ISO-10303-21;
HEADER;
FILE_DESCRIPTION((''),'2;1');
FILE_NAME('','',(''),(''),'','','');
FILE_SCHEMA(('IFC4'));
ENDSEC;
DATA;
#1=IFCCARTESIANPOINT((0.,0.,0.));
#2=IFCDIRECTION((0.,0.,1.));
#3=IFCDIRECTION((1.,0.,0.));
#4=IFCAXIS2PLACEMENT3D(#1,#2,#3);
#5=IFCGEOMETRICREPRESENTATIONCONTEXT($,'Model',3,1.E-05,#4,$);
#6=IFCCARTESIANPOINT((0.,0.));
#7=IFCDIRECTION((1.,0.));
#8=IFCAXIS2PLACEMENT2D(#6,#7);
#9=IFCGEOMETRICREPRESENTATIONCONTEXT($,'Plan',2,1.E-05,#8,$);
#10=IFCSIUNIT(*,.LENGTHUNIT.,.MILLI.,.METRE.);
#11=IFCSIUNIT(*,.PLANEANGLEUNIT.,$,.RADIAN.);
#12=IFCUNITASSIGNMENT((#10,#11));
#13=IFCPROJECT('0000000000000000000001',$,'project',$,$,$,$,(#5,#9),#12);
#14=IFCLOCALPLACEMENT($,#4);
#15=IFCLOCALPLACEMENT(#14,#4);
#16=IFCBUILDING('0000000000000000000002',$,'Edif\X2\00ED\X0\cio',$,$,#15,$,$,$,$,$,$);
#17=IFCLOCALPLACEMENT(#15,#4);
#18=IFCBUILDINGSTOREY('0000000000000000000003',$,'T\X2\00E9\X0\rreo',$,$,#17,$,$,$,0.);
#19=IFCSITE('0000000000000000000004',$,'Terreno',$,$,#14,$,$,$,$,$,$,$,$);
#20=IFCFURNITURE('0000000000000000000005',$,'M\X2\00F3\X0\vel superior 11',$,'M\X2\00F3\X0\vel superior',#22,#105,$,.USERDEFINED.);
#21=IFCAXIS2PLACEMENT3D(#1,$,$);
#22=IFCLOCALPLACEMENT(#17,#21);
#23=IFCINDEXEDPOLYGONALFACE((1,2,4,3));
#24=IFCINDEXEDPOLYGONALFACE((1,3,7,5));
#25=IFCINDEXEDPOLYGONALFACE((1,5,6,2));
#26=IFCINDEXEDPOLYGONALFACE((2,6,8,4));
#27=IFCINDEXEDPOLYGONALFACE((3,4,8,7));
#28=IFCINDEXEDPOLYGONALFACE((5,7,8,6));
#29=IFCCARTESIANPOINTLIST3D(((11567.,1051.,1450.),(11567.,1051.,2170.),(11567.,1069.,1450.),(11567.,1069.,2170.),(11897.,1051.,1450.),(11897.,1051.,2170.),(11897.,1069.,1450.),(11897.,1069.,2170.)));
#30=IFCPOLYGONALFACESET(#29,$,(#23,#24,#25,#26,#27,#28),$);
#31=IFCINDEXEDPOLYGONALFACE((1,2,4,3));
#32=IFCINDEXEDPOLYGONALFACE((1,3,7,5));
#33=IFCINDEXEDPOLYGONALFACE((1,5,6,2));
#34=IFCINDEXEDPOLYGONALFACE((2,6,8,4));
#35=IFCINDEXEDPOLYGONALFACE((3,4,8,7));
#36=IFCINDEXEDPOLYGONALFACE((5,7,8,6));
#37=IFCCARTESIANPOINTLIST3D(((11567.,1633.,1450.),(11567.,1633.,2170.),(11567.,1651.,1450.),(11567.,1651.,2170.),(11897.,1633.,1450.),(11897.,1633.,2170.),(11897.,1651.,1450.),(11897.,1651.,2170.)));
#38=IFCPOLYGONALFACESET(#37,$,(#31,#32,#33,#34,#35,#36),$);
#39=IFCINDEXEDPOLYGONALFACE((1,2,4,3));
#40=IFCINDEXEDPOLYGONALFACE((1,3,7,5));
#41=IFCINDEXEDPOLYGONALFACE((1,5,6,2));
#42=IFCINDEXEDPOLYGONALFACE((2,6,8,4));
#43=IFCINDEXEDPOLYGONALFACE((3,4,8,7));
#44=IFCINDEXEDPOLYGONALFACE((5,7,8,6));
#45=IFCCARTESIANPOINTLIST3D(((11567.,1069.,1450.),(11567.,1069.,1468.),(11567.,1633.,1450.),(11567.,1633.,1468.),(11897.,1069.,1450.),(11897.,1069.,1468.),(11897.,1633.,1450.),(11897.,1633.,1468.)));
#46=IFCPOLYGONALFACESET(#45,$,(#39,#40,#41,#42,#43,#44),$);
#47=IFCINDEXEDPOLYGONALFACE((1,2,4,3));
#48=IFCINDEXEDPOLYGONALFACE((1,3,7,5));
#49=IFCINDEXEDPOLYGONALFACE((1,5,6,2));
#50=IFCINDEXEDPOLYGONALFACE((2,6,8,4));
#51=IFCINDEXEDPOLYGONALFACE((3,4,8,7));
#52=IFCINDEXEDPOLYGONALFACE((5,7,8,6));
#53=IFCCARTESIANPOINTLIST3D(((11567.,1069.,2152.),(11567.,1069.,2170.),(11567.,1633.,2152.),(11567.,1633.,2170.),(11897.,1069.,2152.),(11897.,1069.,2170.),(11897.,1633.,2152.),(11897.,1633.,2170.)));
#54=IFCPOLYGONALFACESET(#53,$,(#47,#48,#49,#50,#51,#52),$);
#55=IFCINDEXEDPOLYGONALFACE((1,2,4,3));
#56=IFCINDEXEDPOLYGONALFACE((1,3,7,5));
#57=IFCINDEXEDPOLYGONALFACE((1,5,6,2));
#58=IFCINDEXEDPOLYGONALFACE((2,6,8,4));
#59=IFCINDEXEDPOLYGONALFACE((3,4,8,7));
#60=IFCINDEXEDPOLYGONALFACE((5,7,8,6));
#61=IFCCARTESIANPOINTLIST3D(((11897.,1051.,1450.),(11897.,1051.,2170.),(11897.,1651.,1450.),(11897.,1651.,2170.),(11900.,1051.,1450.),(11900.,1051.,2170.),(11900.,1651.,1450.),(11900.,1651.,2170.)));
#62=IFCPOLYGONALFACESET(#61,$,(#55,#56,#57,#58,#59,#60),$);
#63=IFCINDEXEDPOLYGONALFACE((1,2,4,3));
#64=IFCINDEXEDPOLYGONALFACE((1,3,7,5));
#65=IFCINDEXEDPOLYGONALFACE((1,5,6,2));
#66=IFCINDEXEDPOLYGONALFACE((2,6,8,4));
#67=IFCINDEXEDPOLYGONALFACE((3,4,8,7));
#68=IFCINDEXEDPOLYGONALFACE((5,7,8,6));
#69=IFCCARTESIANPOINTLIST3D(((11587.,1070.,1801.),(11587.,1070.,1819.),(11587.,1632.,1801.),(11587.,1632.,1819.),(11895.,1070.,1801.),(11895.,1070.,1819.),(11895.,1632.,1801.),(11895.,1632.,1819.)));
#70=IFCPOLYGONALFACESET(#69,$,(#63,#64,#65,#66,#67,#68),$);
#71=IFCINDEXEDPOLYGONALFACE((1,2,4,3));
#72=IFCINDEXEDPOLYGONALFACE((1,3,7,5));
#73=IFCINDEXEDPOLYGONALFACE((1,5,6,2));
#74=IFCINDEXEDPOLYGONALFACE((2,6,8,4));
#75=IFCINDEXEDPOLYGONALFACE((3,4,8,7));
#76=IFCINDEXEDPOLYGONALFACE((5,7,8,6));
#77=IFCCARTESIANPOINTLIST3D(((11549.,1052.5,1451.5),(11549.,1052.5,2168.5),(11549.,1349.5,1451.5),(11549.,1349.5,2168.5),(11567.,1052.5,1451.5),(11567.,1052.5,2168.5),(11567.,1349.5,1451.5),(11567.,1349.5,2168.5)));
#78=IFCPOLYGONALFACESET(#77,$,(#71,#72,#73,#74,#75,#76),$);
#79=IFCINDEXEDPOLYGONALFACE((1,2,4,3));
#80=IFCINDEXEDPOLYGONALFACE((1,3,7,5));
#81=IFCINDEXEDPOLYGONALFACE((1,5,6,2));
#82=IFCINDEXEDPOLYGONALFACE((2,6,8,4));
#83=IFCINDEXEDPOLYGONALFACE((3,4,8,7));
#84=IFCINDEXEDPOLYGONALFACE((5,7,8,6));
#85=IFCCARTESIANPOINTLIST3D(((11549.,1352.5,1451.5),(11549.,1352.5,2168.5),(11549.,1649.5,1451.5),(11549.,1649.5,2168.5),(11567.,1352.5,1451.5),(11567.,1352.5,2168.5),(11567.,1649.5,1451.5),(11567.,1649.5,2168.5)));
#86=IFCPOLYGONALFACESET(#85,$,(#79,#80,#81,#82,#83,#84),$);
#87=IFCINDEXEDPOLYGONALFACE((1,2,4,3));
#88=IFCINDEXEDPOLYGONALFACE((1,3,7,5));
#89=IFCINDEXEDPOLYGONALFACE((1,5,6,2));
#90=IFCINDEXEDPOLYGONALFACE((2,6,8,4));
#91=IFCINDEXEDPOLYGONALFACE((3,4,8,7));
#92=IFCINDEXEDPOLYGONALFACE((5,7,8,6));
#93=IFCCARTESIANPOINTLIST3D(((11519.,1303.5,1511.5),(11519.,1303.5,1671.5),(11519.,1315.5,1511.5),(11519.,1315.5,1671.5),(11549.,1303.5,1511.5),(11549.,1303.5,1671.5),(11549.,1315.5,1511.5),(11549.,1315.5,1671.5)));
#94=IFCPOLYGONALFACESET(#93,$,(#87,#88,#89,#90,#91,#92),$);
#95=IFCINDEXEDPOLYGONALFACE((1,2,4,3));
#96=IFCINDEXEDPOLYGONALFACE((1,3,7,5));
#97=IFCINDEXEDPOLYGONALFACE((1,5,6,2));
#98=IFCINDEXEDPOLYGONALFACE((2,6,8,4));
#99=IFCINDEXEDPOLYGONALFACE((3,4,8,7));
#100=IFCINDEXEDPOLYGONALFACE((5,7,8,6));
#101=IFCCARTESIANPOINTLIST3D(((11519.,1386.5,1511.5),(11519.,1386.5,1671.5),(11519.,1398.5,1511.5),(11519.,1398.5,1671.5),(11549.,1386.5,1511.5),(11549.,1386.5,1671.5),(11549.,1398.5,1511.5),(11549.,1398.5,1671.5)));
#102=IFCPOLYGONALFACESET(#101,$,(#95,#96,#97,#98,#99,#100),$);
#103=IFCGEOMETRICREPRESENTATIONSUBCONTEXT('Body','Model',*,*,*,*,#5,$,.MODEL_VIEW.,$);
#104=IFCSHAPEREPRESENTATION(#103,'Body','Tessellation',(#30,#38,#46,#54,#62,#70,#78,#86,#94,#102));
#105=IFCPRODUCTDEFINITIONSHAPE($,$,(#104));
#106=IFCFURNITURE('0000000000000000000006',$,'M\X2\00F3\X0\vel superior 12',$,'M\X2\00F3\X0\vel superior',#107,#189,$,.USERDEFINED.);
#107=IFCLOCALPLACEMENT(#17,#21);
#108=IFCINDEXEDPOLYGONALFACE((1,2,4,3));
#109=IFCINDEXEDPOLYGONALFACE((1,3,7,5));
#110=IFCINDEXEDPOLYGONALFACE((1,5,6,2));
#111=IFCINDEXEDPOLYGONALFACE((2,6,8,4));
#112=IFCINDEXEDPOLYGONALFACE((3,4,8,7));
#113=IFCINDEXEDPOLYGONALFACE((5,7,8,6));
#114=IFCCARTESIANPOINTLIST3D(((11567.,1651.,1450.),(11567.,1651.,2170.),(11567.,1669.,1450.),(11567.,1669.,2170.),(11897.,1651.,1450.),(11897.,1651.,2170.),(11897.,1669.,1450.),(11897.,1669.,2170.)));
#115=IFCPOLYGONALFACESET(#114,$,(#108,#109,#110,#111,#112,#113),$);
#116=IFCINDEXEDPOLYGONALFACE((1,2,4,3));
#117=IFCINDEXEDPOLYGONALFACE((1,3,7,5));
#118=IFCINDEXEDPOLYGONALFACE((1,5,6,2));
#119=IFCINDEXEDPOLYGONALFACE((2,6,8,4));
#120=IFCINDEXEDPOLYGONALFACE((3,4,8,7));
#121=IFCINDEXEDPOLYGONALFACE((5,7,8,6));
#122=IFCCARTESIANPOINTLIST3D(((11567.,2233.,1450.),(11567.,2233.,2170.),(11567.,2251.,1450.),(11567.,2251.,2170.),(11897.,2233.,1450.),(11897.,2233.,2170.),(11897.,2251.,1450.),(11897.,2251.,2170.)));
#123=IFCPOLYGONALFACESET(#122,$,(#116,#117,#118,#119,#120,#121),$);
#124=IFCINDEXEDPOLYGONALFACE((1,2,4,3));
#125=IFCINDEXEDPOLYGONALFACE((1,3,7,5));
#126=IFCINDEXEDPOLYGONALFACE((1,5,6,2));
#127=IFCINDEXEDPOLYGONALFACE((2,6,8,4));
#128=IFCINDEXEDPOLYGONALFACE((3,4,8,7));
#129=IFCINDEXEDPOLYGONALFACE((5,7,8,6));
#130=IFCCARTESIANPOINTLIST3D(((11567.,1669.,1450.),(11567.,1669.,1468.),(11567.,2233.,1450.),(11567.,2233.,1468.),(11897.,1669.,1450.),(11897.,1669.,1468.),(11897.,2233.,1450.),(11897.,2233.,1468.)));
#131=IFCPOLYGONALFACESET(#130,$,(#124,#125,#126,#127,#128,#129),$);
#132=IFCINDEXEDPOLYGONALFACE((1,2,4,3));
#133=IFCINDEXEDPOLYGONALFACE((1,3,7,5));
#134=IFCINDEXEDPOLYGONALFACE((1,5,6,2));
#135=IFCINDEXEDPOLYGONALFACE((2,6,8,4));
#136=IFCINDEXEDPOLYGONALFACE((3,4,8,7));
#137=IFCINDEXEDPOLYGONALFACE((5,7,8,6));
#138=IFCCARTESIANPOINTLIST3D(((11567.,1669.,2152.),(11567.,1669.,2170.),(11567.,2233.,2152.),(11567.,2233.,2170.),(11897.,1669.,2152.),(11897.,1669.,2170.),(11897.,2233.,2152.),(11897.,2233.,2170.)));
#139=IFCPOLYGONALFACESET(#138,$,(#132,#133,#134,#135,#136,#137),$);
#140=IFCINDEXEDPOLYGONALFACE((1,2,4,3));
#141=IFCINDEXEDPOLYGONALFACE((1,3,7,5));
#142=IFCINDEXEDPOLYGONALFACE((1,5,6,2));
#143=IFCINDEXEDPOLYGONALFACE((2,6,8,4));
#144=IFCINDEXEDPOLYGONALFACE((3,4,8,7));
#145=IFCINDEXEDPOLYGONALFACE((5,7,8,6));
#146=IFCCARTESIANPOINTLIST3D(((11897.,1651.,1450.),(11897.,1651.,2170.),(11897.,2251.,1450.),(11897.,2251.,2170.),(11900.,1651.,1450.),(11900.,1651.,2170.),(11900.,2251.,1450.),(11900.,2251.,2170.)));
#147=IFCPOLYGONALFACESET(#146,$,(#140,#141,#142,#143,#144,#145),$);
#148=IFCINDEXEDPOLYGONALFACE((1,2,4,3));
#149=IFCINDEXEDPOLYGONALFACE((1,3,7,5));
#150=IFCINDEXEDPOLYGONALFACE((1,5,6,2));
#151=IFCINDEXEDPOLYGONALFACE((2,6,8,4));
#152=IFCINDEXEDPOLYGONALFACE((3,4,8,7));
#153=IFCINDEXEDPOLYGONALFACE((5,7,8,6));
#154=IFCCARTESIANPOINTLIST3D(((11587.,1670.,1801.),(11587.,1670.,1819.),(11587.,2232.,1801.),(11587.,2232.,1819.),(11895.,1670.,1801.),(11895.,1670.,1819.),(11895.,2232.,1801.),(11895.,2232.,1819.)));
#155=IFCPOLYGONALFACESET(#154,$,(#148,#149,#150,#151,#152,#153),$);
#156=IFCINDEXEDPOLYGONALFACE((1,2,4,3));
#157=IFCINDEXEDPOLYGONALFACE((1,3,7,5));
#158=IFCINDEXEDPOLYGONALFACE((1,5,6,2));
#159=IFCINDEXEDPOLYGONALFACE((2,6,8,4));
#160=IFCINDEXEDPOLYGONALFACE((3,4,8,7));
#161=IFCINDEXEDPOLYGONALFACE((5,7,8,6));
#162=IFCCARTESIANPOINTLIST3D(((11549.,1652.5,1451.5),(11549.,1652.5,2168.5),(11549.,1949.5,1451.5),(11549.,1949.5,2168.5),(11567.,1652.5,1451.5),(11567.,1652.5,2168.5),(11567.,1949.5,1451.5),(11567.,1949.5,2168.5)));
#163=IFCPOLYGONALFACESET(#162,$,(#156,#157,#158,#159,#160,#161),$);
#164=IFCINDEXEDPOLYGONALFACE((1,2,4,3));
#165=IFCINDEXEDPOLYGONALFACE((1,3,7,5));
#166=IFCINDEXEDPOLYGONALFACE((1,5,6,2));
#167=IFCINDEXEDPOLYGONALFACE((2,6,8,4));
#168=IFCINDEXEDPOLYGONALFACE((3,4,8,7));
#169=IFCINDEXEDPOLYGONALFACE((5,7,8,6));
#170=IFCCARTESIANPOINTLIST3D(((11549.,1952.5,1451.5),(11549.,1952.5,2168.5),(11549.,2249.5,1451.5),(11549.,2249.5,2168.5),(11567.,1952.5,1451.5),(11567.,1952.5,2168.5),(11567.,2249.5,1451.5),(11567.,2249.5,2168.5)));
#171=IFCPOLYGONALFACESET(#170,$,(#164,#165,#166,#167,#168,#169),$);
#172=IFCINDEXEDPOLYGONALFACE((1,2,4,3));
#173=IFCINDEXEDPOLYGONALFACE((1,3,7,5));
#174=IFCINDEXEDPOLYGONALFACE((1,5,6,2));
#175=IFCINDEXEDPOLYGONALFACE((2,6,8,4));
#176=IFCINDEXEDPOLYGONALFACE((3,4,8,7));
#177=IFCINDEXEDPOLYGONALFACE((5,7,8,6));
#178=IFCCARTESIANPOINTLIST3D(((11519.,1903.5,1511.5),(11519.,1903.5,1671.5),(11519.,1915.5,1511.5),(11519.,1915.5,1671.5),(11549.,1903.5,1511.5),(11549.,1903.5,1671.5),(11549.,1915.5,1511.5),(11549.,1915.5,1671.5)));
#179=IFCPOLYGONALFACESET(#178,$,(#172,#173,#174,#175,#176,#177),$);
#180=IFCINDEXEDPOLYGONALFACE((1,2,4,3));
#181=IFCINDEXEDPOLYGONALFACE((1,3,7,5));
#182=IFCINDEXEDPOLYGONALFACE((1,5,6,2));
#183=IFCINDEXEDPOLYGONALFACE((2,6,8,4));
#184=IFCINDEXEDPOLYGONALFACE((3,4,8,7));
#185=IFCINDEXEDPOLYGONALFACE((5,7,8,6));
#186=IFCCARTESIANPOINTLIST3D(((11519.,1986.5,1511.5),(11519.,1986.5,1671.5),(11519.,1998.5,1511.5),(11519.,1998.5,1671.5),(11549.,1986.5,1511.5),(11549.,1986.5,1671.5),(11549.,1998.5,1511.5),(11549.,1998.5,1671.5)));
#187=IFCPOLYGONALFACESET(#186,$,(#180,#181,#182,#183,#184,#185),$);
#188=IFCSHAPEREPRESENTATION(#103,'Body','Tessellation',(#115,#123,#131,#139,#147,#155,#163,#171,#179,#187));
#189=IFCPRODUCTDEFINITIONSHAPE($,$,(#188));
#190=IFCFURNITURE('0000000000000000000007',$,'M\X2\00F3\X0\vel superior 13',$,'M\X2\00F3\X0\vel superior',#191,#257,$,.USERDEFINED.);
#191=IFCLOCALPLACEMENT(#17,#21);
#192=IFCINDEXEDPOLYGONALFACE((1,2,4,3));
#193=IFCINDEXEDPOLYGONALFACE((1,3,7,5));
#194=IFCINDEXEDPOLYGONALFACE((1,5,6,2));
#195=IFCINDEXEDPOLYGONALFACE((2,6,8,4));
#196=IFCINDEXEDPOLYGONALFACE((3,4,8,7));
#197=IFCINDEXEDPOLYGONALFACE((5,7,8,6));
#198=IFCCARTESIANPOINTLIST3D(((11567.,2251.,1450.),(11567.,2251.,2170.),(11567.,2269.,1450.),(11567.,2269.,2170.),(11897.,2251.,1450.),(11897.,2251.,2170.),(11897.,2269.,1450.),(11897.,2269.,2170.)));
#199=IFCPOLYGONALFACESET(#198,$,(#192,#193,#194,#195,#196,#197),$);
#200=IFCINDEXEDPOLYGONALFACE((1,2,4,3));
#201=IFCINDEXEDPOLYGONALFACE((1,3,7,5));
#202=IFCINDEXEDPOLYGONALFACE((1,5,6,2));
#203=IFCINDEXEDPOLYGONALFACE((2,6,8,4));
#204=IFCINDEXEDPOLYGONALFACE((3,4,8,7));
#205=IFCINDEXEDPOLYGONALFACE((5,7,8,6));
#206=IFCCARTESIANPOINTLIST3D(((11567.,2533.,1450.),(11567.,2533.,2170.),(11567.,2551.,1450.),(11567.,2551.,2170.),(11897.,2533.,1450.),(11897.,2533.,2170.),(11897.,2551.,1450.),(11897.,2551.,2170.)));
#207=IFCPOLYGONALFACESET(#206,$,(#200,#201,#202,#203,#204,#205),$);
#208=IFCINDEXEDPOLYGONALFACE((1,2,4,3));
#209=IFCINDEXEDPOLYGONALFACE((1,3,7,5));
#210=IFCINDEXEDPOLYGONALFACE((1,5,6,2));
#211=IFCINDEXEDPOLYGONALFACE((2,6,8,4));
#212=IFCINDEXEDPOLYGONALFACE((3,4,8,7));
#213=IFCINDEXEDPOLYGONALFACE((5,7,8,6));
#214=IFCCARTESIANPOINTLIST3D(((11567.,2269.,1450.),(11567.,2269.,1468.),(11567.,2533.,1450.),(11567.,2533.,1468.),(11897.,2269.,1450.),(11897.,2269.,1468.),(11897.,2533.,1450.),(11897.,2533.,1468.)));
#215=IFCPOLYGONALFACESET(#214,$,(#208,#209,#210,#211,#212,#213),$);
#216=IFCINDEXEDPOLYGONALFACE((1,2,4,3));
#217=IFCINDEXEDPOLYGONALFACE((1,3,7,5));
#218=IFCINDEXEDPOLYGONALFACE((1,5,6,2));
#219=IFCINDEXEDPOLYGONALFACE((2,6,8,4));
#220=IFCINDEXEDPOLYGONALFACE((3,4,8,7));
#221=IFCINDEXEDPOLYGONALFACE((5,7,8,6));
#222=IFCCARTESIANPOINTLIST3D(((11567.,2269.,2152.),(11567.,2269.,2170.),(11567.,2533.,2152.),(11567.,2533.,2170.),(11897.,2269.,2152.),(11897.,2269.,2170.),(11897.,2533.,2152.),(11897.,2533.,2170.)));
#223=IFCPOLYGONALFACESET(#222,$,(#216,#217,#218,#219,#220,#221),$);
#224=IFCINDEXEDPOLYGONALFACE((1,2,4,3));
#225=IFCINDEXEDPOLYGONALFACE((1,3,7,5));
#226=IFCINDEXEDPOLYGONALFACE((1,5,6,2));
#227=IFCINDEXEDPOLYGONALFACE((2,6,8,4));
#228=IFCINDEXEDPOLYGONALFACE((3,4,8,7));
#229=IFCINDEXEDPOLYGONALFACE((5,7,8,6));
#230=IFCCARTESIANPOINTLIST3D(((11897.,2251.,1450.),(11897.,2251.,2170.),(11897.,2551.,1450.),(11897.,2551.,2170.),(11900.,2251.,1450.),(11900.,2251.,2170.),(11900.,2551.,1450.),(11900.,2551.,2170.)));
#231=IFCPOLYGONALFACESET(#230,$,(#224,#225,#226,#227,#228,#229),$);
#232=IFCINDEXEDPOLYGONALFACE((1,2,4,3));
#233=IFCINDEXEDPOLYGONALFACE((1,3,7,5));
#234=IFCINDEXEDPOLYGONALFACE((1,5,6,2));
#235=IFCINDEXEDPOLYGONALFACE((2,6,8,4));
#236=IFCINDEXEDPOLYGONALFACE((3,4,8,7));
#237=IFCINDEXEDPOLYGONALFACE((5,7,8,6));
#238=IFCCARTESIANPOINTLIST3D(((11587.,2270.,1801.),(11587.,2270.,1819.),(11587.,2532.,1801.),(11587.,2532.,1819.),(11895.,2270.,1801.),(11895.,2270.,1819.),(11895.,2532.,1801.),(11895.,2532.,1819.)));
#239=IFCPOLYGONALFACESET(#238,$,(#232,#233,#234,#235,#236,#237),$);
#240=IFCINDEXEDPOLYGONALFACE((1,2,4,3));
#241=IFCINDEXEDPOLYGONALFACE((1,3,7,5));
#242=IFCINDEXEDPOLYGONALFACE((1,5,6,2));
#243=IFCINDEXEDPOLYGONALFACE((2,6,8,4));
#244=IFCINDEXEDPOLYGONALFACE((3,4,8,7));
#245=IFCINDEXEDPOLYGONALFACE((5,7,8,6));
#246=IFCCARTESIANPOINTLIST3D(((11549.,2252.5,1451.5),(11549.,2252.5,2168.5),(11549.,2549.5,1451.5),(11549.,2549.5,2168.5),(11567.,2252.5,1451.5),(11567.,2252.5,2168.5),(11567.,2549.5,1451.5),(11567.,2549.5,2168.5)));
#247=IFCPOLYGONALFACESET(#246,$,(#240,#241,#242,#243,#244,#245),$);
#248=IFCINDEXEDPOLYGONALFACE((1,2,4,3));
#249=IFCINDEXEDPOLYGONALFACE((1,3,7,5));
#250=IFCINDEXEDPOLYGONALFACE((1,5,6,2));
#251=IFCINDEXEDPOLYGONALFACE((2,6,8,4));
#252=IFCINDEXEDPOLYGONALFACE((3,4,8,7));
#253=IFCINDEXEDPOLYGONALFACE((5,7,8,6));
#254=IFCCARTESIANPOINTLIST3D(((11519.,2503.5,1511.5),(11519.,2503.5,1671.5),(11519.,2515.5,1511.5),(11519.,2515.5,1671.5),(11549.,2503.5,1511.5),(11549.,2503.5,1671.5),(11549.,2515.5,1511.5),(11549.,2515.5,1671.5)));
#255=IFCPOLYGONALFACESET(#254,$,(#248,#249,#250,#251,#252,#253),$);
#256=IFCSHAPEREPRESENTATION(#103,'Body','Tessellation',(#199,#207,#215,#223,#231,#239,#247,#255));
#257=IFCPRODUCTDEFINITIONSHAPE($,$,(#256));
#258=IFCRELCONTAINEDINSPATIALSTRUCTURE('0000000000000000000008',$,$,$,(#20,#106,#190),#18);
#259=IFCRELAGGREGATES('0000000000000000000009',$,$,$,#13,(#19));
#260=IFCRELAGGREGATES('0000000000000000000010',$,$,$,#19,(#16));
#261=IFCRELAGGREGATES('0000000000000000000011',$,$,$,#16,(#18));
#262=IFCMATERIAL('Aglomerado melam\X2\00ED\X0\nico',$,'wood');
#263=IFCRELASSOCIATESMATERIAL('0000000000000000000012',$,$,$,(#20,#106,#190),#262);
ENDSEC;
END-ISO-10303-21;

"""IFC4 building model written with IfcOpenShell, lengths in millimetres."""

from ifc_helpers import new_model, si_unit, frame, frame_2d, origin_with_axes, origin_2d_with_axis, place, context, subcontext, project, spatial, rectangle, extrude, material, element, save


model = new_model("IFC4")

# Units and contexts
model_context = context("Model", 3, precision=1e-05, world=origin_with_axes())
plan_context = context("Plan", 2, precision=1e-05, world=origin_2d_with_axis())
body_context = subcontext(model_context, "Body", "Model", "MODEL_VIEW")
ifc_project = project(units=[si_unit("LENGTHUNIT", "METRE", prefix="MILLI"), si_unit("PLANEANGLEUNIT", "RADIAN")], contexts=[model_context, plan_context])

# Site, building, storey
site_placement = place(None, origin_with_axes())
site = spatial("IfcSite", under=ifc_project, at=site_placement, Name="Terreno")
building_placement = place(site_placement, origin_with_axes())
building = spatial("IfcBuilding", under=site, at=building_placement, Name="Edifício")
storey_placement = place(building_placement, origin_with_axes())
storey = spatial("IfcBuildingStorey", under=building, at=storey_placement, Name="Térreo", Elevation=0.0)

# Furniture
ifc_material_1 = material(Name="Aglomerado melamínico", Category="wood")
for number, where, z_axis, x_axis, name in (
    (1, (11900.0, 1051.0, 0.0), (0.0, 0.0, 1.0), (0.0, 1.0, 0.0), "Móvel superior 11"),
    (2, (11900.0, 1651.0, 0.0), (0.0, 0.0, 1.0), (0.0, 1.0, 0.0), "Móvel superior 12"),
):
    element("IfcFurniture", number, at=place(storey_placement, frame(where, z_axis=z_axis, x_axis=x_axis)), inside=storey, material=ifc_material_1, Name=name, ObjectType="Móvel superior", PredefinedType="USERDEFINED", context=body_context, shape_type="SweptSolid", body=[
        extrude(rectangle(XDim=18.0, YDim=330.0, at=frame_2d((9.0, 168.0))), frame((0.0, 0.0, 1450.0)), (0.0, 0.0, 1.0), 720.0),
        extrude(rectangle(XDim=18.0, YDim=330.0, at=frame_2d((591.0, 168.0))), frame((0.0, 0.0, 1450.0)), (0.0, 0.0, 1.0), 720.0),
        extrude(rectangle(XDim=564.0, YDim=330.0, at=frame_2d((300.0, 168.0))), frame((0.0, 0.0, 1450.0)), (0.0, 0.0, 1.0), 18.0),
        extrude(rectangle(XDim=564.0, YDim=330.0, at=frame_2d((300.0, 168.0))), frame((0.0, 0.0, 2152.0)), (0.0, 0.0, 1.0), 18.0),
        extrude(rectangle(XDim=600.0, YDim=3.0, at=frame_2d((300.0, 1.5))), frame((0.0, 0.0, 1450.0)), (0.0, 0.0, 1.0), 720.0),
        extrude(rectangle(XDim=562.0, YDim=308.0, at=frame_2d((300.0, 159.0))), frame((0.0, 0.0, 1801.0)), (0.0, 0.0, 1.0), 18.0),
        extrude(rectangle(XDim=297.0, YDim=18.0, at=frame_2d((150.0, 342.0))), frame((0.0, 0.0, 1451.5)), (0.0, 0.0, 1.0), 717.0),
        extrude(rectangle(XDim=297.0, YDim=18.0, at=frame_2d((450.0, 342.0))), frame((0.0, 0.0, 1451.5)), (0.0, 0.0, 1.0), 717.0),
        extrude(rectangle(XDim=12.0, YDim=30.0, at=frame_2d((258.5, 366.0))), frame((0.0, 0.0, 1511.5)), (0.0, 0.0, 1.0), 160.0),
        extrude(rectangle(XDim=12.0, YDim=30.0, at=frame_2d((341.5, 366.0))), frame((0.0, 0.0, 1511.5)), (0.0, 0.0, 1.0), 160.0),
    ])
furniture_1_placement = place(storey_placement, frame((11900.0, 2251.0, 0.0), z_axis=(0.0, 0.0, 1.0), x_axis=(0.0, 1.0, 0.0)))
element("IfcFurniture", 3, at=furniture_1_placement, inside=storey, material=ifc_material_1, Name="Móvel superior 13", ObjectType="Móvel superior", PredefinedType="USERDEFINED", context=body_context, shape_type="SweptSolid", body=[
    extrude(rectangle(XDim=18.0, YDim=330.0, at=frame_2d((9.0, 168.0))), frame((0.0, 0.0, 1450.0)), (0.0, 0.0, 1.0), 720.0),
    extrude(rectangle(XDim=18.0, YDim=330.0, at=frame_2d((291.0, 168.0))), frame((0.0, 0.0, 1450.0)), (0.0, 0.0, 1.0), 720.0),
    extrude(rectangle(XDim=264.0, YDim=330.0, at=frame_2d((150.0, 168.0))), frame((0.0, 0.0, 1450.0)), (0.0, 0.0, 1.0), 18.0),
    extrude(rectangle(XDim=264.0, YDim=330.0, at=frame_2d((150.0, 168.0))), frame((0.0, 0.0, 2152.0)), (0.0, 0.0, 1.0), 18.0),
    extrude(rectangle(XDim=300.0, YDim=3.0, at=frame_2d((150.0, 1.5))), frame((0.0, 0.0, 1450.0)), (0.0, 0.0, 1.0), 720.0),
    extrude(rectangle(XDim=262.0, YDim=308.0, at=frame_2d((150.0, 159.0))), frame((0.0, 0.0, 1801.0)), (0.0, 0.0, 1.0), 18.0),
    extrude(rectangle(XDim=297.0, YDim=18.0, at=frame_2d((150.0, 342.0))), frame((0.0, 0.0, 1451.5)), (0.0, 0.0, 1.0), 717.0),
    extrude(rectangle(XDim=12.0, YDim=30.0, at=frame_2d((258.5, 366.0))), frame((0.0, 0.0, 1511.5)), (0.0, 0.0, 1.0), 160.0),
])

save(model, "model.ifc")
